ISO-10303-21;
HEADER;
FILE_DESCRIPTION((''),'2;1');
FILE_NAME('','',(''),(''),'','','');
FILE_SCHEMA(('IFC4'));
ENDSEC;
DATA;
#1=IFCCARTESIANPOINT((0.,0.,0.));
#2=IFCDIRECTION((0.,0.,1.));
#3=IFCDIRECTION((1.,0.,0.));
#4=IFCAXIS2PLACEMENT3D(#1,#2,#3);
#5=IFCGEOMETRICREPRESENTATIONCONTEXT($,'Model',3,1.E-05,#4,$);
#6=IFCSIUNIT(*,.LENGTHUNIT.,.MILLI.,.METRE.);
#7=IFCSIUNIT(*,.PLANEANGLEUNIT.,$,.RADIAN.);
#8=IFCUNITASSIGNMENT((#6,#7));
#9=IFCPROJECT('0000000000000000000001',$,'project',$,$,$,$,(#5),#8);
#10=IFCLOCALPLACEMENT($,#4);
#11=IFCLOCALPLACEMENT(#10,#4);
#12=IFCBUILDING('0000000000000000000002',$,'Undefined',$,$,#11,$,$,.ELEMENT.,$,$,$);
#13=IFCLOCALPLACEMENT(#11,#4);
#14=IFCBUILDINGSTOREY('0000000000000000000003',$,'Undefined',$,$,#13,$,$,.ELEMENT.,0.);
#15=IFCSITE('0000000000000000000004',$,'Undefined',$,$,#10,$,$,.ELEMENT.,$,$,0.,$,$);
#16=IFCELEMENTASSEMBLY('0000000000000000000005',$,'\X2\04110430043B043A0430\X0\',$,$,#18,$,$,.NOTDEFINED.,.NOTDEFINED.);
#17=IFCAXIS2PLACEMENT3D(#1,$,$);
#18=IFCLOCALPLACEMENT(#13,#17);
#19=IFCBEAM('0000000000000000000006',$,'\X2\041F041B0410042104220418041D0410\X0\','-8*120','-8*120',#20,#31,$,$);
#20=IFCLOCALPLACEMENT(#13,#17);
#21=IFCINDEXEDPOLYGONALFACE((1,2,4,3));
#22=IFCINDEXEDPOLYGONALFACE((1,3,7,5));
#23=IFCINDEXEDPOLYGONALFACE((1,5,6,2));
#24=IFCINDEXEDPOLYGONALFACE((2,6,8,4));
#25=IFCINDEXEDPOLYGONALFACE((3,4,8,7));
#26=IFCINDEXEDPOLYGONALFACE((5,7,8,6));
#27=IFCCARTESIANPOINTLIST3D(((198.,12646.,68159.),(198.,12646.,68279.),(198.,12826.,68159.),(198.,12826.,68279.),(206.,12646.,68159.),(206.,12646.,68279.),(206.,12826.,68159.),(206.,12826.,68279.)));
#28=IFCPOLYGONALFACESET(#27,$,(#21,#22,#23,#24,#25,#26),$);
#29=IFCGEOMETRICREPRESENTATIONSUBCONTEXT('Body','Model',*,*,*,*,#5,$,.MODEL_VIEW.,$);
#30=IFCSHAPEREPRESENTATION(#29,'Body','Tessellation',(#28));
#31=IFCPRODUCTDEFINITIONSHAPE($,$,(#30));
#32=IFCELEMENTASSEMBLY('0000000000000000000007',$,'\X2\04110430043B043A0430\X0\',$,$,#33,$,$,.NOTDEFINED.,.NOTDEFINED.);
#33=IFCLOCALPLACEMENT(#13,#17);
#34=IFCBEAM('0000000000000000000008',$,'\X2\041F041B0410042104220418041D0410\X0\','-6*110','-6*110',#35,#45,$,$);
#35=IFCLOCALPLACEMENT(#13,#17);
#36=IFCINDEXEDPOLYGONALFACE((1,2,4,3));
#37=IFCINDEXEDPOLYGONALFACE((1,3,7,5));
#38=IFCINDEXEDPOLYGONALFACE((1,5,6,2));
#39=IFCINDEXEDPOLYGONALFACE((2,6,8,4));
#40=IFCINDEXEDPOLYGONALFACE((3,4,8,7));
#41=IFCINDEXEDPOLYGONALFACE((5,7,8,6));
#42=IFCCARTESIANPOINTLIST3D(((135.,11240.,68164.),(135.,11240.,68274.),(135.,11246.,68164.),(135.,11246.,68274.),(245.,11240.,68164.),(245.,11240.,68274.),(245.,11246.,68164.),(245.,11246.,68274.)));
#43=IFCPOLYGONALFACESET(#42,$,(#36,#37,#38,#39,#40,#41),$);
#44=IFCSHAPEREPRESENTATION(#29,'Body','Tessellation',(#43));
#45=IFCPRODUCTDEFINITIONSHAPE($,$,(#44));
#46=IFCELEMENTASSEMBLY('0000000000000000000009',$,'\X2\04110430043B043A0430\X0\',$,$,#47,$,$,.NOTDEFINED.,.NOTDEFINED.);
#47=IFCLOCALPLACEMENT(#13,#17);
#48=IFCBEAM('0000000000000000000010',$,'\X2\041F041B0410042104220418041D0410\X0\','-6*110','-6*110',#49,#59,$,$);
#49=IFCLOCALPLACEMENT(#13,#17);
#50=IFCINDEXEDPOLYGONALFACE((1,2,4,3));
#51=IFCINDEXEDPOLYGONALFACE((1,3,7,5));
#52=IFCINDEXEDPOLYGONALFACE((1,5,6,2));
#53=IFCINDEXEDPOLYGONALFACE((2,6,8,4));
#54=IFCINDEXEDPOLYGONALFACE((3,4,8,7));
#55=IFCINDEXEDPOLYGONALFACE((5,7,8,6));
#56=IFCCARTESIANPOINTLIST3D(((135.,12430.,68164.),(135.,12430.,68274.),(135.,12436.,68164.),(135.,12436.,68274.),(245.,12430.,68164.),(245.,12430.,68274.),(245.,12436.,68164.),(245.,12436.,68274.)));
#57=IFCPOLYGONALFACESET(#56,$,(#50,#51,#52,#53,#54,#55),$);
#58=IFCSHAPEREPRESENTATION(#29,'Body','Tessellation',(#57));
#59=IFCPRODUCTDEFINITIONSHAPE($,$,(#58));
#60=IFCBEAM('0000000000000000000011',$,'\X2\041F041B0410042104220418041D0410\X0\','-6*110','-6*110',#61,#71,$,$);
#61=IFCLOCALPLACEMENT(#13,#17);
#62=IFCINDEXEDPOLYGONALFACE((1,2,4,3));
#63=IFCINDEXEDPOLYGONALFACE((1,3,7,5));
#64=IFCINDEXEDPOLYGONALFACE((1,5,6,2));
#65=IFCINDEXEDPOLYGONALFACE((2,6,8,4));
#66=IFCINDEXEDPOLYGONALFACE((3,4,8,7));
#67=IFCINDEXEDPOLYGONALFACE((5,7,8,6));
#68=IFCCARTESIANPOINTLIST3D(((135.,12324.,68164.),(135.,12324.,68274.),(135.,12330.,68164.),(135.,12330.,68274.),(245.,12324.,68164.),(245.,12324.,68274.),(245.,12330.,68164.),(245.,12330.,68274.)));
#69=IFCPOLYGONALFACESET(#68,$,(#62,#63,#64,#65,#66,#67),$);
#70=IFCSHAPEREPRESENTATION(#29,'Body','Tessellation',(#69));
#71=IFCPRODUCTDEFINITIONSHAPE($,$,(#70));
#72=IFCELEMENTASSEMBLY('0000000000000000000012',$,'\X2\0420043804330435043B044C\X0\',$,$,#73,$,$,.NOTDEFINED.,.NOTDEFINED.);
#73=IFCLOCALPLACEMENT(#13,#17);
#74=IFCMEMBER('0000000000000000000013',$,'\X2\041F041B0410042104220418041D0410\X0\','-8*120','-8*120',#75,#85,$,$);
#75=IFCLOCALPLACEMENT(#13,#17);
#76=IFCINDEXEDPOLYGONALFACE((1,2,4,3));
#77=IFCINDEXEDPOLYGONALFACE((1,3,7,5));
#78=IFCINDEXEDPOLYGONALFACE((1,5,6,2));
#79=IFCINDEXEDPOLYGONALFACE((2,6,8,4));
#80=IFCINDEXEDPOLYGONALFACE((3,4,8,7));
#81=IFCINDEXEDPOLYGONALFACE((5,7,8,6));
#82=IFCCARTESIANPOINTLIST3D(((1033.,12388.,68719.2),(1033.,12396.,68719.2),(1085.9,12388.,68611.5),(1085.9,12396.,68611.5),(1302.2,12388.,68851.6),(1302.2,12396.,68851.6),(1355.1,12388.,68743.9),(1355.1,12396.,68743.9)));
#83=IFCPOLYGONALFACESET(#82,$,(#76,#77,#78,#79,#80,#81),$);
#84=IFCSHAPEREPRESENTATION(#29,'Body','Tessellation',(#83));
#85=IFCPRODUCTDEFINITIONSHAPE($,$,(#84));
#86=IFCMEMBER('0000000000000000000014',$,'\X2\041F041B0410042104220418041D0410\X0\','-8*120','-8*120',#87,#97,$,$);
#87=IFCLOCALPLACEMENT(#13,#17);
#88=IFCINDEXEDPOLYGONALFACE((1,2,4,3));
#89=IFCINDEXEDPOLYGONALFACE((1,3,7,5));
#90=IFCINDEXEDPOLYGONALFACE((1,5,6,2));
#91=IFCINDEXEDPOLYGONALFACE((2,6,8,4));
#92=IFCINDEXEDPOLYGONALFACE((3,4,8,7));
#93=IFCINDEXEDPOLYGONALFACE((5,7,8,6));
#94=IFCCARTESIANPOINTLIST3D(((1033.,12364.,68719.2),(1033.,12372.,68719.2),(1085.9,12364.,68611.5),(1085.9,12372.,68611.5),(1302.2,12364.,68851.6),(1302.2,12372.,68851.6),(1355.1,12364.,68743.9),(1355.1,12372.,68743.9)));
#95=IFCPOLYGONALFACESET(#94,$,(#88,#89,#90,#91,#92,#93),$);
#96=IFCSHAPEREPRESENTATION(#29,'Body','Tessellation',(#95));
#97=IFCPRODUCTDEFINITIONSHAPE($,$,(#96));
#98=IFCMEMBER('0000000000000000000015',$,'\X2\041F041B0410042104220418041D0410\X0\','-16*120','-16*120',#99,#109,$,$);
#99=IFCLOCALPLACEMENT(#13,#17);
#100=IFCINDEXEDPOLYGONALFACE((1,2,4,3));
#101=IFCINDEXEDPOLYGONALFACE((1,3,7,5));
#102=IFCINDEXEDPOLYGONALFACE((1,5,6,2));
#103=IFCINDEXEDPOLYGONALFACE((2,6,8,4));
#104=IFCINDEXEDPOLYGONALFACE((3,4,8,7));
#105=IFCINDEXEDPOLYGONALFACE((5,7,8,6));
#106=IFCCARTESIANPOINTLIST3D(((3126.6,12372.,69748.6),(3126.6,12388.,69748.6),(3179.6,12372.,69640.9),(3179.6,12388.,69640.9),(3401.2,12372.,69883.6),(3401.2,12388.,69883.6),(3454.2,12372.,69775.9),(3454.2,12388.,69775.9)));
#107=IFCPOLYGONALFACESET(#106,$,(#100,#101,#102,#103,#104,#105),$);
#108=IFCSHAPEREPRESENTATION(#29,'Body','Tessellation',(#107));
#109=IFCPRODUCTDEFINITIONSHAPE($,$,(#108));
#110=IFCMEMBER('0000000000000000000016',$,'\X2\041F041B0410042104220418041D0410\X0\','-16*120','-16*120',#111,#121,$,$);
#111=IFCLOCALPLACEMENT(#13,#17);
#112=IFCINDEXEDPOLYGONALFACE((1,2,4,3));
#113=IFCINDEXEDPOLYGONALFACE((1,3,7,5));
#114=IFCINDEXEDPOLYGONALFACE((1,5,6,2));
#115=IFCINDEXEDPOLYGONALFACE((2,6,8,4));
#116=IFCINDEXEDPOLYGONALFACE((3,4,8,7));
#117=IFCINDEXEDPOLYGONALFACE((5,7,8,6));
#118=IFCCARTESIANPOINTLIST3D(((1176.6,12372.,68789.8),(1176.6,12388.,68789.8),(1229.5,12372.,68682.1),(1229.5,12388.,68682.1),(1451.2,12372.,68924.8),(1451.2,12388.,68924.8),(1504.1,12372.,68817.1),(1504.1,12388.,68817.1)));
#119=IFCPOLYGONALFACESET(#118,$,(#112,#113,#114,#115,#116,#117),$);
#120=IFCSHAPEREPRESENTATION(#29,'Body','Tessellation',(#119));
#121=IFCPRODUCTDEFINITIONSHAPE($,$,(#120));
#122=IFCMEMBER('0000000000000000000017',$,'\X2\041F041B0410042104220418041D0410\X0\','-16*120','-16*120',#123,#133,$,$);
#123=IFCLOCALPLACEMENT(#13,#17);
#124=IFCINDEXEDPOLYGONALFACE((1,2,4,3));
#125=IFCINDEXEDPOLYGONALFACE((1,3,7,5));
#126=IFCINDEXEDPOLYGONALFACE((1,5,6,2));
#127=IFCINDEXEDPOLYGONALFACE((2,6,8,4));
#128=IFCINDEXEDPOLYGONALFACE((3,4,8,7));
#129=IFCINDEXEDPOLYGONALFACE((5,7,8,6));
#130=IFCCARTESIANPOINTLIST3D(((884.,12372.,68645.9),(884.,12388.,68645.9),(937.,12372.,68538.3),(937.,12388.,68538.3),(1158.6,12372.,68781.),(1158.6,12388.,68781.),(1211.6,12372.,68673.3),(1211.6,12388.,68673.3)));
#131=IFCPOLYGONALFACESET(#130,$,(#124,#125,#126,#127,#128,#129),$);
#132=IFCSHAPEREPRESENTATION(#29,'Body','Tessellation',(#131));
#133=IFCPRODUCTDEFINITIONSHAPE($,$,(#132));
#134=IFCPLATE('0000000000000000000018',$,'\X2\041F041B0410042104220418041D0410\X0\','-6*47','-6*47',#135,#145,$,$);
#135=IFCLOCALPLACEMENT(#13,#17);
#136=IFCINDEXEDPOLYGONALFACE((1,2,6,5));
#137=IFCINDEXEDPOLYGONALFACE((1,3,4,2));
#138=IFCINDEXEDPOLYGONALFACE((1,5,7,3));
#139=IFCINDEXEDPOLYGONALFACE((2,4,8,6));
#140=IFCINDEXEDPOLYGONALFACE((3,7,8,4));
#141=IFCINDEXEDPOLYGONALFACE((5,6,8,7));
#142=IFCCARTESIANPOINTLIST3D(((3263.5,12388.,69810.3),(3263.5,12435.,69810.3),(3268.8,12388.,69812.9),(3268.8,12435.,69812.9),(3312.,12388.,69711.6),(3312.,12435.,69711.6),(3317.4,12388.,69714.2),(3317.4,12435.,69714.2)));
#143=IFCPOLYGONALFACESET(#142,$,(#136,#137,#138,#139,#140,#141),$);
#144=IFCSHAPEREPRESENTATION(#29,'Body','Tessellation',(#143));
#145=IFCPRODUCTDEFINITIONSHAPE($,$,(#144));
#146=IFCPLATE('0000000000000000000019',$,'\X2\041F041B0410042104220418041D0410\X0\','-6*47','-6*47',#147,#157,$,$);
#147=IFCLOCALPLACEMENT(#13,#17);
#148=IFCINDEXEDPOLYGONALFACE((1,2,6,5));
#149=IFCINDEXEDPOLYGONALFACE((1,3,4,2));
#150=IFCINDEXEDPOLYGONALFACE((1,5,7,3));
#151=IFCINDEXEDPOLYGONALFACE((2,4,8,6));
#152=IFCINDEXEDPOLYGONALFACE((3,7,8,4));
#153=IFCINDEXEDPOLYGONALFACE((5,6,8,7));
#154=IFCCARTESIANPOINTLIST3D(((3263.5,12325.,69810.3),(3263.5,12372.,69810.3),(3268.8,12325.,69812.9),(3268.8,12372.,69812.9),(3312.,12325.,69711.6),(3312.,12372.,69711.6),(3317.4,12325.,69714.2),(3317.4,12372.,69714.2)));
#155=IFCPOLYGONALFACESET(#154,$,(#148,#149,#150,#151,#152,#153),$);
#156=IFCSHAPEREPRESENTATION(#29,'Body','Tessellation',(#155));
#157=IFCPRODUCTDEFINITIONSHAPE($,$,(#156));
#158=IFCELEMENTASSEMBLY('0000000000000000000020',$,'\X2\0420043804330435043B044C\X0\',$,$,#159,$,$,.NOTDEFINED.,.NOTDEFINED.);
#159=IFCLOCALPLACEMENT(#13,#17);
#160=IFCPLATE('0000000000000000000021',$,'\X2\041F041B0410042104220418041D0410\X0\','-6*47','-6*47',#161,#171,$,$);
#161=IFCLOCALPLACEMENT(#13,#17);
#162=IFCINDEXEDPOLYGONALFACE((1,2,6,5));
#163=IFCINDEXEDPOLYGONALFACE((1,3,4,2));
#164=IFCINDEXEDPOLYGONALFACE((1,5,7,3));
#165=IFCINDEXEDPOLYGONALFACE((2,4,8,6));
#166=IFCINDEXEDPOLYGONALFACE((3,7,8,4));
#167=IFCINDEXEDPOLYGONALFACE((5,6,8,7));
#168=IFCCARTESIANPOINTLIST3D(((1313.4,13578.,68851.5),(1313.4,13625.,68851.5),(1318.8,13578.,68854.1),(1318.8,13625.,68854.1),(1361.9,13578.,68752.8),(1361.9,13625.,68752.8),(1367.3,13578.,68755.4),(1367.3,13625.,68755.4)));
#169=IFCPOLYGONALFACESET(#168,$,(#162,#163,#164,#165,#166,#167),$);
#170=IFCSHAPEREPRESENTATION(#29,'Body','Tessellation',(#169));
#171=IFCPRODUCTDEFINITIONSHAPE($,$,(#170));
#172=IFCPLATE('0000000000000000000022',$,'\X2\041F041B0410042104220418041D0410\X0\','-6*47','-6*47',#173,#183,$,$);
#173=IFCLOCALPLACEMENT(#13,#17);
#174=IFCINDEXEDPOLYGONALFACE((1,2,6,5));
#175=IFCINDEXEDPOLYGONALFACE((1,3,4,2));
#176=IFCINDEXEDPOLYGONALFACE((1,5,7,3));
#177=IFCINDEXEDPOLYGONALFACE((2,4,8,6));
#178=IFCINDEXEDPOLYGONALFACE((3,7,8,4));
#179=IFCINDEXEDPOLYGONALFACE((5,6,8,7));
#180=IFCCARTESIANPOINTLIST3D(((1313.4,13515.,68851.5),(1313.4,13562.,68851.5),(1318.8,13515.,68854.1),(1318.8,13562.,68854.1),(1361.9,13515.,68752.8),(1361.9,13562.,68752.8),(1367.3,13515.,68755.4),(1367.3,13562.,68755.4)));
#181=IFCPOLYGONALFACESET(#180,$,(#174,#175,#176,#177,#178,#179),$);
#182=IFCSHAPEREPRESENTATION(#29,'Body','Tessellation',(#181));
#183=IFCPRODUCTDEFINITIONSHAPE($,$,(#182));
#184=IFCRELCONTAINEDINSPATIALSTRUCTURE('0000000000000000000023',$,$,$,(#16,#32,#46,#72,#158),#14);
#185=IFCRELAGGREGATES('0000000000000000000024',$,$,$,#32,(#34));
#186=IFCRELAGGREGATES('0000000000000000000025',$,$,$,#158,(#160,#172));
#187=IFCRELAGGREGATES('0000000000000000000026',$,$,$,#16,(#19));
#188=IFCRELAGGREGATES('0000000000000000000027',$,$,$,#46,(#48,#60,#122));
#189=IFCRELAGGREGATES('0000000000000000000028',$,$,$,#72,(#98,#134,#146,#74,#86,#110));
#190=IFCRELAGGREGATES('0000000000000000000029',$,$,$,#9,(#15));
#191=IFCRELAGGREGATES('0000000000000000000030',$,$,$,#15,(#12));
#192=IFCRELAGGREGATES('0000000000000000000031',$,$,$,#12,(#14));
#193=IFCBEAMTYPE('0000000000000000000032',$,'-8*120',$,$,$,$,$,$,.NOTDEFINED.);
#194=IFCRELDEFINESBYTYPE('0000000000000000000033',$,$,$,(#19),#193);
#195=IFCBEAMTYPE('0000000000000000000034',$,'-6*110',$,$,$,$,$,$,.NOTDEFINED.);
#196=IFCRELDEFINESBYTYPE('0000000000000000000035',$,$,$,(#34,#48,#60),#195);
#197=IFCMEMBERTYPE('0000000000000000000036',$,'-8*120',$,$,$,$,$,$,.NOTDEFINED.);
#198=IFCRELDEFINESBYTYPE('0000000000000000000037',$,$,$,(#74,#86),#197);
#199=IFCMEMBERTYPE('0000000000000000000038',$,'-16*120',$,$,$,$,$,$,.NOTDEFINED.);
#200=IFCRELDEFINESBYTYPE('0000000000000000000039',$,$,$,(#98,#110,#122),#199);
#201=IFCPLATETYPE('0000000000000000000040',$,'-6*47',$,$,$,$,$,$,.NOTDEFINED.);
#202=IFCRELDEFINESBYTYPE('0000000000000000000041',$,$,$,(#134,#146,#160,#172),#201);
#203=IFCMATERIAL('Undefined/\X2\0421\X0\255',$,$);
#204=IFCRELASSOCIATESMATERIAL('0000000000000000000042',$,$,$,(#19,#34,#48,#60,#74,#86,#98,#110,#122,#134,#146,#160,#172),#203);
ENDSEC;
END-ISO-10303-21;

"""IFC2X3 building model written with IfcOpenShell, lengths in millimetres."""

from ifc_helpers import new_model, si_unit, frame, origin_with_axes, origin_2d_with_axis, place, context, subcontext, project, spatial, polyline, rectangle, outline, extrude, boolean, material, type_object, element, aggregate, save


model = new_model("IFC2X3")

# Units and contexts
model_context = context("Model", 3, precision=1e-05, world=origin_with_axes())
body_context = subcontext(model_context, "Body", "Model", "MODEL_VIEW")
ifc_project = project(units=[si_unit("LENGTHUNIT", "METRE", prefix="MILLI"), si_unit("PLANEANGLEUNIT", "RADIAN")], contexts=[model_context])

# Site, building, storey
site_placement = place(None, origin_with_axes())
site = spatial("IfcSite", under=ifc_project, at=site_placement, Name="Undefined", CompositionType="ELEMENT", RefElevation=0.0)
building_placement = place(site_placement, origin_with_axes())
building = spatial("IfcBuilding", under=site, at=building_placement, Name="Undefined", CompositionType="ELEMENT")
storey_placement = place(building_placement, origin_with_axes())
storey = spatial("IfcBuildingStorey", under=building, at=storey_placement, Name="Undefined", CompositionType="ELEMENT", Elevation=0.0)

# Element assemblies, beams
assembly_1_placement = place(storey_placement, origin_with_axes())
assembly_1 = element("IfcElementAssembly", 1, at=assembly_1_placement, inside=storey, Name="Балка", AssemblyPlace="NOTDEFINED", PredefinedType="NOTDEFINED")
ifc_material_1 = material(Name="Undefined/С255")
beam_type_1 = type_object("IfcBeamType", Name="-8*120", PredefinedType="NOTDEFINED")
beam_1_placement = place(assembly_1_placement, frame((202.0, 12826.0, 68219.0), z_axis=(0.0, 0.0, -1.0), x_axis=(0.0, -1.0, 0.0)))
beam_1 = element("IfcBeam", 2, at=beam_1_placement, type_object=beam_type_1, material=ifc_material_1, Name="ПЛАСТИНА", Description="-8*120", ObjectType="-8*120", context=body_context, shape_type="SweptSolid", body=[
    extrude(rectangle(XDim=8.0, YDim=120.0, at=origin_2d_with_axis()), frame((180.0, 0.0, 0.0), z_axis=(-1.0, 0.0, 0.0), x_axis=(0.0, -1.0, 0.0)), (0.0, 0.0, 1.0), 180.0),
])
assembly_2_placement = place(storey_placement, origin_with_axes())
assembly_2 = element("IfcElementAssembly", 3, at=assembly_2_placement, inside=storey, Name="Балка", AssemblyPlace="NOTDEFINED", PredefinedType="NOTDEFINED")
beam_type_2 = type_object("IfcBeamType", Name="-6*110", PredefinedType="NOTDEFINED")
beam_2_placement = place(assembly_2_placement, frame((245.0, 11243.0, 68219.0), z_axis=(0.0, 0.0, 1.0), x_axis=(-1.0, 0.0, 0.0)))
beam_2 = element("IfcBeam", 4, at=beam_2_placement, type_object=beam_type_2, material=ifc_material_1, Name="ПЛАСТИНА", Description="-6*110", ObjectType="-6*110", context=body_context, shape_type="SweptSolid", body=[
    extrude(rectangle(XDim=6.0, YDim=110.0, at=origin_2d_with_axis()), frame((110.0, 0.0, 0.0), z_axis=(-1.0, 0.0, 0.0), x_axis=(0.0, -1.0, 0.0)), (0.0, 0.0, 1.0), 110.0),
])
aggregate(assembly_2, [beam_2])

# Element assembly, beams
assembly_3_placement = place(storey_placement, origin_with_axes())
assembly_3 = element("IfcElementAssembly", 5, at=assembly_3_placement, inside=storey, Name="Балка", AssemblyPlace="NOTDEFINED", PredefinedType="NOTDEFINED")
beam_3_placement = place(assembly_3_placement, frame((245.0, 12433.0, 68219.0), z_axis=(0.0, 0.0, 1.0), x_axis=(-1.0, 0.0, 0.0)))
beam_3 = element("IfcBeam", 6, at=beam_3_placement, type_object=beam_type_2, material=ifc_material_1, Name="ПЛАСТИНА", Description="-6*110", ObjectType="-6*110", context=body_context, shape_type="SweptSolid", body=[
    extrude(rectangle(XDim=6.0, YDim=110.0, at=origin_2d_with_axis()), frame((110.0, 0.0, 0.0), z_axis=(-1.0, 0.0, 0.0), x_axis=(0.0, -1.0, 0.0)), (0.0, 0.0, 1.0), 110.0),
])
beam_4_placement = place(assembly_3_placement, frame((245.0, 12327.0, 68219.0), z_axis=(0.0, 0.0, -1.0), x_axis=(-1.0, 0.0, 0.0)))
beam_4 = element("IfcBeam", 7, at=beam_4_placement, type_object=beam_type_2, material=ifc_material_1, Name="ПЛАСТИНА", Description="-6*110", ObjectType="-6*110", context=body_context, shape_type="SweptSolid", body=[
    extrude(rectangle(XDim=6.0, YDim=110.0, at=origin_2d_with_axis()), frame((110.0, 0.0, 0.0), z_axis=(-1.0, 0.0, 0.0), x_axis=(0.0, -1.0, 0.0)), (0.0, 0.0, 1.0), 110.0),
])

# Element assembly, members
assembly_4_placement = place(storey_placement, origin_with_axes())
assembly_4 = element("IfcElementAssembly", 8, at=assembly_4_placement, inside=storey, Name="Ригель", AssemblyPlace="NOTDEFINED", PredefinedType="NOTDEFINED")
member_type_1 = type_object("IfcMemberType", Name="-8*120", PredefinedType="NOTDEFINED")
member_1_placement = place(assembly_4_placement, frame((1059.5, 12392.0, 68665.3), z_axis=(0.441221, 0.0, -0.897399), x_axis=(0.897399, 0.0, 0.441221)))
member_1 = element("IfcMember", 9, at=member_1_placement, type_object=member_type_1, material=ifc_material_1, Name="ПЛАСТИНА", Description="-8*120", ObjectType="-8*120", context=body_context, shape_type="SweptSolid", body=[
    extrude(rectangle(XDim=8.0, YDim=120.0, at=origin_2d_with_axis()), frame((300.0, 0.0, 0.0), z_axis=(-1.0, 0.0, 0.0), x_axis=(0.0, -1.0, 0.0)), (0.0, 0.0, 1.0), 300.0),
])
member_2_placement = place(assembly_4_placement, frame((1059.5, 12368.0, 68665.3), z_axis=(0.441221, 0.0, -0.897399), x_axis=(0.897399, 0.0, 0.441221)))
member_2 = element("IfcMember", 10, at=member_2_placement, type_object=member_type_1, material=ifc_material_1, Name="ПЛАСТИНА", Description="-8*120", ObjectType="-8*120", context=body_context, shape_type="SweptSolid", body=[
    extrude(rectangle(XDim=8.0, YDim=120.0, at=origin_2d_with_axis()), frame((300.0, 0.0, 0.0), z_axis=(-1.0, 0.0, 0.0), x_axis=(0.0, -1.0, 0.0)), (0.0, 0.0, 1.0), 300.0),
])
member_type_2 = type_object("IfcMemberType", Name="-16*120", PredefinedType="NOTDEFINED")
member_3_placement = place(assembly_4_placement, frame((3153.1, 12380.0, 69694.7), z_axis=(0.441221, 0.0, -0.897399), x_axis=(0.897399, 0.0, 0.441221)))
member_3 = element("IfcMember", 11, at=member_3_placement, type_object=member_type_2, material=ifc_material_1, Name="ПЛАСТИНА", Description="-16*120", ObjectType="-16*120", context=body_context, shape_type="SweptSolid", body=[
    extrude(rectangle(XDim=16.0, YDim=120.0, at=origin_2d_with_axis()), frame((306.0, 0.0, 0.0), z_axis=(-1.0, 0.0, 0.0), x_axis=(0.0, -1.0, 0.0)), (0.0, 0.0, 1.0), 306.0),
])
member_4_placement = place(assembly_4_placement, frame((1203.0, 12380.0, 68735.9), z_axis=(0.441221, 0.0, -0.897399), x_axis=(0.897399, 0.0, 0.441221)))
member_4 = element("IfcMember", 12, at=member_4_placement, type_object=member_type_2, material=ifc_material_1, Name="ПЛАСТИНА", Description="-16*120", ObjectType="-16*120", context=body_context, shape_type="SweptSolid", body=[
    extrude(rectangle(XDim=16.0, YDim=120.0, at=origin_2d_with_axis()), frame((306.0, 0.0, 0.0), z_axis=(-1.0, 0.0, 0.0), x_axis=(0.0, -1.0, 0.0)), (0.0, 0.0, 1.0), 306.0),
])

# Member
member_5_placement = place(assembly_3_placement, frame((910.5, 12380.0, 68592.1), z_axis=(0.441221, 0.0, -0.897399), x_axis=(0.897399, 0.0, 0.441221)))
member_5 = element("IfcMember", 13, at=member_5_placement, type_object=member_type_2, material=ifc_material_1, Name="ПЛАСТИНА", Description="-16*120", ObjectType="-16*120", context=body_context, shape_type="SweptSolid", body=[
    extrude(rectangle(XDim=16.0, YDim=120.0, at=origin_2d_with_axis()), frame((306.0, 0.0, 0.0), z_axis=(-1.0, 0.0, 0.0), x_axis=(0.0, -1.0, 0.0)), (0.0, 0.0, 1.0), 306.0),
])

# Plates
plate_type = type_object("IfcPlateType", Name="-6*47", PredefinedType="NOTDEFINED")
plate_1_placement = place(assembly_4_placement, frame((3266.1, 12325.0, 69811.6), z_axis=(0.897399, 0.0, 0.441221), x_axis=(0.441221, 0.0, -0.897399)))
plate_1 = element("IfcPlate", 14, at=plate_1_placement, type_object=plate_type, material=ifc_material_1, Name="ПЛАСТИНА", Description="-6*47", ObjectType="-6*47", context=body_context, shape_type="CSG", body=[
    boolean("DIFFERENCE", extrude(outline(polyline([(0.0, 0.0), (110.0, 0.0), (110.0, 110.0), (0.0, 110.0), (0.0, 0.0)])), frame((0.0, 0.0, -3.0), z_axis=(0.0, 0.0, 1.0), x_axis=(1.0, 0.0, 0.0)), (0.0, 0.0, 1.0), 6.0), extrude(rectangle(XDim=26.0, YDim=130.0, at=origin_2d_with_axis()), frame((55.0, -3.0, 0.0), z_axis=(0.0, 1.0, 0.0), x_axis=(0.0, 0.0, -1.0)), (0.0, 0.0, 1.0), 66.0)),
])
plate_2_placement = place(assembly_4_placement, frame((3266.1, 12325.0, 69811.6), z_axis=(0.897399, 0.0, 0.441221), x_axis=(0.441221, 0.0, -0.897399)))
plate_2 = element("IfcPlate", 15, at=plate_2_placement, type_object=plate_type, material=ifc_material_1, Name="ПЛАСТИНА", Description="-6*47", ObjectType="-6*47", context=body_context, shape_type="CSG", body=[
    boolean("DIFFERENCE", extrude(outline(polyline([(0.0, 0.0), (110.0, 0.0), (110.0, 110.0), (0.0, 110.0), (0.0, 0.0)])), frame((0.0, 0.0, -3.0), z_axis=(0.0, 0.0, 1.0), x_axis=(1.0, 0.0, 0.0)), (0.0, 0.0, 1.0), 6.0), extrude(rectangle(XDim=26.0, YDim=130.0, at=origin_2d_with_axis()), frame((55.0, 47.0, 0.0), z_axis=(0.0, 1.0, 0.0), x_axis=(0.0, 0.0, -1.0)), (0.0, 0.0, 1.0), 66.0)),
])

# Element assembly, plates
assembly_5_placement = place(storey_placement, origin_with_axes())
assembly_5 = element("IfcElementAssembly", 16, at=assembly_5_placement, inside=storey, Name="Ригель", AssemblyPlace="NOTDEFINED", PredefinedType="NOTDEFINED")
plate_3_placement = place(assembly_5_placement, frame((1364.6, 13515.0, 68754.1), z_axis=(-0.897399, 0.0, -0.441221), x_axis=(-0.441221, 0.0, 0.897399)))
plate_3 = element("IfcPlate", 17, at=plate_3_placement, type_object=plate_type, material=ifc_material_1, Name="ПЛАСТИНА", Description="-6*47", ObjectType="-6*47", context=body_context, shape_type="CSG", body=[
    boolean("DIFFERENCE", extrude(outline(polyline([(0.0, 0.0), (110.0, 0.0), (110.0, 110.0), (0.0, 110.0), (0.0, 0.0)])), frame((0.0, 0.0, -3.0), z_axis=(0.0, 0.0, 1.0), x_axis=(1.0, 0.0, 0.0)), (0.0, 0.0, 1.0), 6.0), extrude(rectangle(XDim=26.0, YDim=130.0, at=origin_2d_with_axis()), frame((55.0, -3.0, 0.0), z_axis=(0.0, 1.0, 0.0), x_axis=(0.0, 0.0, -1.0)), (0.0, 0.0, 1.0), 66.0)),
])
plate_4_placement = place(assembly_5_placement, frame((1364.6, 13515.0, 68754.1), z_axis=(-0.897399, 0.0, -0.441221), x_axis=(-0.441221, 0.0, 0.897399)))
plate_4 = element("IfcPlate", 18, at=plate_4_placement, type_object=plate_type, material=ifc_material_1, Name="ПЛАСТИНА", Description="-6*47", ObjectType="-6*47", context=body_context, shape_type="CSG", body=[
    boolean("DIFFERENCE", extrude(outline(polyline([(0.0, 0.0), (110.0, 0.0), (110.0, 110.0), (0.0, 110.0), (0.0, 0.0)])), frame((0.0, 0.0, -3.0), z_axis=(0.0, 0.0, 1.0), x_axis=(1.0, 0.0, 0.0)), (0.0, 0.0, 1.0), 6.0), extrude(rectangle(XDim=26.0, YDim=130.0, at=origin_2d_with_axis()), frame((55.0, 47.0, 0.0), z_axis=(0.0, 1.0, 0.0), x_axis=(0.0, 0.0, -1.0)), (0.0, 0.0, 1.0), 66.0)),
])
aggregate(assembly_5, [plate_3, plate_4])

aggregate(assembly_1, [beam_1])
aggregate(assembly_3, [beam_3, beam_4, member_5])

aggregate(assembly_4, [member_3, plate_1, plate_2, member_1, member_2, member_4])

save(model, "model.ifc")
